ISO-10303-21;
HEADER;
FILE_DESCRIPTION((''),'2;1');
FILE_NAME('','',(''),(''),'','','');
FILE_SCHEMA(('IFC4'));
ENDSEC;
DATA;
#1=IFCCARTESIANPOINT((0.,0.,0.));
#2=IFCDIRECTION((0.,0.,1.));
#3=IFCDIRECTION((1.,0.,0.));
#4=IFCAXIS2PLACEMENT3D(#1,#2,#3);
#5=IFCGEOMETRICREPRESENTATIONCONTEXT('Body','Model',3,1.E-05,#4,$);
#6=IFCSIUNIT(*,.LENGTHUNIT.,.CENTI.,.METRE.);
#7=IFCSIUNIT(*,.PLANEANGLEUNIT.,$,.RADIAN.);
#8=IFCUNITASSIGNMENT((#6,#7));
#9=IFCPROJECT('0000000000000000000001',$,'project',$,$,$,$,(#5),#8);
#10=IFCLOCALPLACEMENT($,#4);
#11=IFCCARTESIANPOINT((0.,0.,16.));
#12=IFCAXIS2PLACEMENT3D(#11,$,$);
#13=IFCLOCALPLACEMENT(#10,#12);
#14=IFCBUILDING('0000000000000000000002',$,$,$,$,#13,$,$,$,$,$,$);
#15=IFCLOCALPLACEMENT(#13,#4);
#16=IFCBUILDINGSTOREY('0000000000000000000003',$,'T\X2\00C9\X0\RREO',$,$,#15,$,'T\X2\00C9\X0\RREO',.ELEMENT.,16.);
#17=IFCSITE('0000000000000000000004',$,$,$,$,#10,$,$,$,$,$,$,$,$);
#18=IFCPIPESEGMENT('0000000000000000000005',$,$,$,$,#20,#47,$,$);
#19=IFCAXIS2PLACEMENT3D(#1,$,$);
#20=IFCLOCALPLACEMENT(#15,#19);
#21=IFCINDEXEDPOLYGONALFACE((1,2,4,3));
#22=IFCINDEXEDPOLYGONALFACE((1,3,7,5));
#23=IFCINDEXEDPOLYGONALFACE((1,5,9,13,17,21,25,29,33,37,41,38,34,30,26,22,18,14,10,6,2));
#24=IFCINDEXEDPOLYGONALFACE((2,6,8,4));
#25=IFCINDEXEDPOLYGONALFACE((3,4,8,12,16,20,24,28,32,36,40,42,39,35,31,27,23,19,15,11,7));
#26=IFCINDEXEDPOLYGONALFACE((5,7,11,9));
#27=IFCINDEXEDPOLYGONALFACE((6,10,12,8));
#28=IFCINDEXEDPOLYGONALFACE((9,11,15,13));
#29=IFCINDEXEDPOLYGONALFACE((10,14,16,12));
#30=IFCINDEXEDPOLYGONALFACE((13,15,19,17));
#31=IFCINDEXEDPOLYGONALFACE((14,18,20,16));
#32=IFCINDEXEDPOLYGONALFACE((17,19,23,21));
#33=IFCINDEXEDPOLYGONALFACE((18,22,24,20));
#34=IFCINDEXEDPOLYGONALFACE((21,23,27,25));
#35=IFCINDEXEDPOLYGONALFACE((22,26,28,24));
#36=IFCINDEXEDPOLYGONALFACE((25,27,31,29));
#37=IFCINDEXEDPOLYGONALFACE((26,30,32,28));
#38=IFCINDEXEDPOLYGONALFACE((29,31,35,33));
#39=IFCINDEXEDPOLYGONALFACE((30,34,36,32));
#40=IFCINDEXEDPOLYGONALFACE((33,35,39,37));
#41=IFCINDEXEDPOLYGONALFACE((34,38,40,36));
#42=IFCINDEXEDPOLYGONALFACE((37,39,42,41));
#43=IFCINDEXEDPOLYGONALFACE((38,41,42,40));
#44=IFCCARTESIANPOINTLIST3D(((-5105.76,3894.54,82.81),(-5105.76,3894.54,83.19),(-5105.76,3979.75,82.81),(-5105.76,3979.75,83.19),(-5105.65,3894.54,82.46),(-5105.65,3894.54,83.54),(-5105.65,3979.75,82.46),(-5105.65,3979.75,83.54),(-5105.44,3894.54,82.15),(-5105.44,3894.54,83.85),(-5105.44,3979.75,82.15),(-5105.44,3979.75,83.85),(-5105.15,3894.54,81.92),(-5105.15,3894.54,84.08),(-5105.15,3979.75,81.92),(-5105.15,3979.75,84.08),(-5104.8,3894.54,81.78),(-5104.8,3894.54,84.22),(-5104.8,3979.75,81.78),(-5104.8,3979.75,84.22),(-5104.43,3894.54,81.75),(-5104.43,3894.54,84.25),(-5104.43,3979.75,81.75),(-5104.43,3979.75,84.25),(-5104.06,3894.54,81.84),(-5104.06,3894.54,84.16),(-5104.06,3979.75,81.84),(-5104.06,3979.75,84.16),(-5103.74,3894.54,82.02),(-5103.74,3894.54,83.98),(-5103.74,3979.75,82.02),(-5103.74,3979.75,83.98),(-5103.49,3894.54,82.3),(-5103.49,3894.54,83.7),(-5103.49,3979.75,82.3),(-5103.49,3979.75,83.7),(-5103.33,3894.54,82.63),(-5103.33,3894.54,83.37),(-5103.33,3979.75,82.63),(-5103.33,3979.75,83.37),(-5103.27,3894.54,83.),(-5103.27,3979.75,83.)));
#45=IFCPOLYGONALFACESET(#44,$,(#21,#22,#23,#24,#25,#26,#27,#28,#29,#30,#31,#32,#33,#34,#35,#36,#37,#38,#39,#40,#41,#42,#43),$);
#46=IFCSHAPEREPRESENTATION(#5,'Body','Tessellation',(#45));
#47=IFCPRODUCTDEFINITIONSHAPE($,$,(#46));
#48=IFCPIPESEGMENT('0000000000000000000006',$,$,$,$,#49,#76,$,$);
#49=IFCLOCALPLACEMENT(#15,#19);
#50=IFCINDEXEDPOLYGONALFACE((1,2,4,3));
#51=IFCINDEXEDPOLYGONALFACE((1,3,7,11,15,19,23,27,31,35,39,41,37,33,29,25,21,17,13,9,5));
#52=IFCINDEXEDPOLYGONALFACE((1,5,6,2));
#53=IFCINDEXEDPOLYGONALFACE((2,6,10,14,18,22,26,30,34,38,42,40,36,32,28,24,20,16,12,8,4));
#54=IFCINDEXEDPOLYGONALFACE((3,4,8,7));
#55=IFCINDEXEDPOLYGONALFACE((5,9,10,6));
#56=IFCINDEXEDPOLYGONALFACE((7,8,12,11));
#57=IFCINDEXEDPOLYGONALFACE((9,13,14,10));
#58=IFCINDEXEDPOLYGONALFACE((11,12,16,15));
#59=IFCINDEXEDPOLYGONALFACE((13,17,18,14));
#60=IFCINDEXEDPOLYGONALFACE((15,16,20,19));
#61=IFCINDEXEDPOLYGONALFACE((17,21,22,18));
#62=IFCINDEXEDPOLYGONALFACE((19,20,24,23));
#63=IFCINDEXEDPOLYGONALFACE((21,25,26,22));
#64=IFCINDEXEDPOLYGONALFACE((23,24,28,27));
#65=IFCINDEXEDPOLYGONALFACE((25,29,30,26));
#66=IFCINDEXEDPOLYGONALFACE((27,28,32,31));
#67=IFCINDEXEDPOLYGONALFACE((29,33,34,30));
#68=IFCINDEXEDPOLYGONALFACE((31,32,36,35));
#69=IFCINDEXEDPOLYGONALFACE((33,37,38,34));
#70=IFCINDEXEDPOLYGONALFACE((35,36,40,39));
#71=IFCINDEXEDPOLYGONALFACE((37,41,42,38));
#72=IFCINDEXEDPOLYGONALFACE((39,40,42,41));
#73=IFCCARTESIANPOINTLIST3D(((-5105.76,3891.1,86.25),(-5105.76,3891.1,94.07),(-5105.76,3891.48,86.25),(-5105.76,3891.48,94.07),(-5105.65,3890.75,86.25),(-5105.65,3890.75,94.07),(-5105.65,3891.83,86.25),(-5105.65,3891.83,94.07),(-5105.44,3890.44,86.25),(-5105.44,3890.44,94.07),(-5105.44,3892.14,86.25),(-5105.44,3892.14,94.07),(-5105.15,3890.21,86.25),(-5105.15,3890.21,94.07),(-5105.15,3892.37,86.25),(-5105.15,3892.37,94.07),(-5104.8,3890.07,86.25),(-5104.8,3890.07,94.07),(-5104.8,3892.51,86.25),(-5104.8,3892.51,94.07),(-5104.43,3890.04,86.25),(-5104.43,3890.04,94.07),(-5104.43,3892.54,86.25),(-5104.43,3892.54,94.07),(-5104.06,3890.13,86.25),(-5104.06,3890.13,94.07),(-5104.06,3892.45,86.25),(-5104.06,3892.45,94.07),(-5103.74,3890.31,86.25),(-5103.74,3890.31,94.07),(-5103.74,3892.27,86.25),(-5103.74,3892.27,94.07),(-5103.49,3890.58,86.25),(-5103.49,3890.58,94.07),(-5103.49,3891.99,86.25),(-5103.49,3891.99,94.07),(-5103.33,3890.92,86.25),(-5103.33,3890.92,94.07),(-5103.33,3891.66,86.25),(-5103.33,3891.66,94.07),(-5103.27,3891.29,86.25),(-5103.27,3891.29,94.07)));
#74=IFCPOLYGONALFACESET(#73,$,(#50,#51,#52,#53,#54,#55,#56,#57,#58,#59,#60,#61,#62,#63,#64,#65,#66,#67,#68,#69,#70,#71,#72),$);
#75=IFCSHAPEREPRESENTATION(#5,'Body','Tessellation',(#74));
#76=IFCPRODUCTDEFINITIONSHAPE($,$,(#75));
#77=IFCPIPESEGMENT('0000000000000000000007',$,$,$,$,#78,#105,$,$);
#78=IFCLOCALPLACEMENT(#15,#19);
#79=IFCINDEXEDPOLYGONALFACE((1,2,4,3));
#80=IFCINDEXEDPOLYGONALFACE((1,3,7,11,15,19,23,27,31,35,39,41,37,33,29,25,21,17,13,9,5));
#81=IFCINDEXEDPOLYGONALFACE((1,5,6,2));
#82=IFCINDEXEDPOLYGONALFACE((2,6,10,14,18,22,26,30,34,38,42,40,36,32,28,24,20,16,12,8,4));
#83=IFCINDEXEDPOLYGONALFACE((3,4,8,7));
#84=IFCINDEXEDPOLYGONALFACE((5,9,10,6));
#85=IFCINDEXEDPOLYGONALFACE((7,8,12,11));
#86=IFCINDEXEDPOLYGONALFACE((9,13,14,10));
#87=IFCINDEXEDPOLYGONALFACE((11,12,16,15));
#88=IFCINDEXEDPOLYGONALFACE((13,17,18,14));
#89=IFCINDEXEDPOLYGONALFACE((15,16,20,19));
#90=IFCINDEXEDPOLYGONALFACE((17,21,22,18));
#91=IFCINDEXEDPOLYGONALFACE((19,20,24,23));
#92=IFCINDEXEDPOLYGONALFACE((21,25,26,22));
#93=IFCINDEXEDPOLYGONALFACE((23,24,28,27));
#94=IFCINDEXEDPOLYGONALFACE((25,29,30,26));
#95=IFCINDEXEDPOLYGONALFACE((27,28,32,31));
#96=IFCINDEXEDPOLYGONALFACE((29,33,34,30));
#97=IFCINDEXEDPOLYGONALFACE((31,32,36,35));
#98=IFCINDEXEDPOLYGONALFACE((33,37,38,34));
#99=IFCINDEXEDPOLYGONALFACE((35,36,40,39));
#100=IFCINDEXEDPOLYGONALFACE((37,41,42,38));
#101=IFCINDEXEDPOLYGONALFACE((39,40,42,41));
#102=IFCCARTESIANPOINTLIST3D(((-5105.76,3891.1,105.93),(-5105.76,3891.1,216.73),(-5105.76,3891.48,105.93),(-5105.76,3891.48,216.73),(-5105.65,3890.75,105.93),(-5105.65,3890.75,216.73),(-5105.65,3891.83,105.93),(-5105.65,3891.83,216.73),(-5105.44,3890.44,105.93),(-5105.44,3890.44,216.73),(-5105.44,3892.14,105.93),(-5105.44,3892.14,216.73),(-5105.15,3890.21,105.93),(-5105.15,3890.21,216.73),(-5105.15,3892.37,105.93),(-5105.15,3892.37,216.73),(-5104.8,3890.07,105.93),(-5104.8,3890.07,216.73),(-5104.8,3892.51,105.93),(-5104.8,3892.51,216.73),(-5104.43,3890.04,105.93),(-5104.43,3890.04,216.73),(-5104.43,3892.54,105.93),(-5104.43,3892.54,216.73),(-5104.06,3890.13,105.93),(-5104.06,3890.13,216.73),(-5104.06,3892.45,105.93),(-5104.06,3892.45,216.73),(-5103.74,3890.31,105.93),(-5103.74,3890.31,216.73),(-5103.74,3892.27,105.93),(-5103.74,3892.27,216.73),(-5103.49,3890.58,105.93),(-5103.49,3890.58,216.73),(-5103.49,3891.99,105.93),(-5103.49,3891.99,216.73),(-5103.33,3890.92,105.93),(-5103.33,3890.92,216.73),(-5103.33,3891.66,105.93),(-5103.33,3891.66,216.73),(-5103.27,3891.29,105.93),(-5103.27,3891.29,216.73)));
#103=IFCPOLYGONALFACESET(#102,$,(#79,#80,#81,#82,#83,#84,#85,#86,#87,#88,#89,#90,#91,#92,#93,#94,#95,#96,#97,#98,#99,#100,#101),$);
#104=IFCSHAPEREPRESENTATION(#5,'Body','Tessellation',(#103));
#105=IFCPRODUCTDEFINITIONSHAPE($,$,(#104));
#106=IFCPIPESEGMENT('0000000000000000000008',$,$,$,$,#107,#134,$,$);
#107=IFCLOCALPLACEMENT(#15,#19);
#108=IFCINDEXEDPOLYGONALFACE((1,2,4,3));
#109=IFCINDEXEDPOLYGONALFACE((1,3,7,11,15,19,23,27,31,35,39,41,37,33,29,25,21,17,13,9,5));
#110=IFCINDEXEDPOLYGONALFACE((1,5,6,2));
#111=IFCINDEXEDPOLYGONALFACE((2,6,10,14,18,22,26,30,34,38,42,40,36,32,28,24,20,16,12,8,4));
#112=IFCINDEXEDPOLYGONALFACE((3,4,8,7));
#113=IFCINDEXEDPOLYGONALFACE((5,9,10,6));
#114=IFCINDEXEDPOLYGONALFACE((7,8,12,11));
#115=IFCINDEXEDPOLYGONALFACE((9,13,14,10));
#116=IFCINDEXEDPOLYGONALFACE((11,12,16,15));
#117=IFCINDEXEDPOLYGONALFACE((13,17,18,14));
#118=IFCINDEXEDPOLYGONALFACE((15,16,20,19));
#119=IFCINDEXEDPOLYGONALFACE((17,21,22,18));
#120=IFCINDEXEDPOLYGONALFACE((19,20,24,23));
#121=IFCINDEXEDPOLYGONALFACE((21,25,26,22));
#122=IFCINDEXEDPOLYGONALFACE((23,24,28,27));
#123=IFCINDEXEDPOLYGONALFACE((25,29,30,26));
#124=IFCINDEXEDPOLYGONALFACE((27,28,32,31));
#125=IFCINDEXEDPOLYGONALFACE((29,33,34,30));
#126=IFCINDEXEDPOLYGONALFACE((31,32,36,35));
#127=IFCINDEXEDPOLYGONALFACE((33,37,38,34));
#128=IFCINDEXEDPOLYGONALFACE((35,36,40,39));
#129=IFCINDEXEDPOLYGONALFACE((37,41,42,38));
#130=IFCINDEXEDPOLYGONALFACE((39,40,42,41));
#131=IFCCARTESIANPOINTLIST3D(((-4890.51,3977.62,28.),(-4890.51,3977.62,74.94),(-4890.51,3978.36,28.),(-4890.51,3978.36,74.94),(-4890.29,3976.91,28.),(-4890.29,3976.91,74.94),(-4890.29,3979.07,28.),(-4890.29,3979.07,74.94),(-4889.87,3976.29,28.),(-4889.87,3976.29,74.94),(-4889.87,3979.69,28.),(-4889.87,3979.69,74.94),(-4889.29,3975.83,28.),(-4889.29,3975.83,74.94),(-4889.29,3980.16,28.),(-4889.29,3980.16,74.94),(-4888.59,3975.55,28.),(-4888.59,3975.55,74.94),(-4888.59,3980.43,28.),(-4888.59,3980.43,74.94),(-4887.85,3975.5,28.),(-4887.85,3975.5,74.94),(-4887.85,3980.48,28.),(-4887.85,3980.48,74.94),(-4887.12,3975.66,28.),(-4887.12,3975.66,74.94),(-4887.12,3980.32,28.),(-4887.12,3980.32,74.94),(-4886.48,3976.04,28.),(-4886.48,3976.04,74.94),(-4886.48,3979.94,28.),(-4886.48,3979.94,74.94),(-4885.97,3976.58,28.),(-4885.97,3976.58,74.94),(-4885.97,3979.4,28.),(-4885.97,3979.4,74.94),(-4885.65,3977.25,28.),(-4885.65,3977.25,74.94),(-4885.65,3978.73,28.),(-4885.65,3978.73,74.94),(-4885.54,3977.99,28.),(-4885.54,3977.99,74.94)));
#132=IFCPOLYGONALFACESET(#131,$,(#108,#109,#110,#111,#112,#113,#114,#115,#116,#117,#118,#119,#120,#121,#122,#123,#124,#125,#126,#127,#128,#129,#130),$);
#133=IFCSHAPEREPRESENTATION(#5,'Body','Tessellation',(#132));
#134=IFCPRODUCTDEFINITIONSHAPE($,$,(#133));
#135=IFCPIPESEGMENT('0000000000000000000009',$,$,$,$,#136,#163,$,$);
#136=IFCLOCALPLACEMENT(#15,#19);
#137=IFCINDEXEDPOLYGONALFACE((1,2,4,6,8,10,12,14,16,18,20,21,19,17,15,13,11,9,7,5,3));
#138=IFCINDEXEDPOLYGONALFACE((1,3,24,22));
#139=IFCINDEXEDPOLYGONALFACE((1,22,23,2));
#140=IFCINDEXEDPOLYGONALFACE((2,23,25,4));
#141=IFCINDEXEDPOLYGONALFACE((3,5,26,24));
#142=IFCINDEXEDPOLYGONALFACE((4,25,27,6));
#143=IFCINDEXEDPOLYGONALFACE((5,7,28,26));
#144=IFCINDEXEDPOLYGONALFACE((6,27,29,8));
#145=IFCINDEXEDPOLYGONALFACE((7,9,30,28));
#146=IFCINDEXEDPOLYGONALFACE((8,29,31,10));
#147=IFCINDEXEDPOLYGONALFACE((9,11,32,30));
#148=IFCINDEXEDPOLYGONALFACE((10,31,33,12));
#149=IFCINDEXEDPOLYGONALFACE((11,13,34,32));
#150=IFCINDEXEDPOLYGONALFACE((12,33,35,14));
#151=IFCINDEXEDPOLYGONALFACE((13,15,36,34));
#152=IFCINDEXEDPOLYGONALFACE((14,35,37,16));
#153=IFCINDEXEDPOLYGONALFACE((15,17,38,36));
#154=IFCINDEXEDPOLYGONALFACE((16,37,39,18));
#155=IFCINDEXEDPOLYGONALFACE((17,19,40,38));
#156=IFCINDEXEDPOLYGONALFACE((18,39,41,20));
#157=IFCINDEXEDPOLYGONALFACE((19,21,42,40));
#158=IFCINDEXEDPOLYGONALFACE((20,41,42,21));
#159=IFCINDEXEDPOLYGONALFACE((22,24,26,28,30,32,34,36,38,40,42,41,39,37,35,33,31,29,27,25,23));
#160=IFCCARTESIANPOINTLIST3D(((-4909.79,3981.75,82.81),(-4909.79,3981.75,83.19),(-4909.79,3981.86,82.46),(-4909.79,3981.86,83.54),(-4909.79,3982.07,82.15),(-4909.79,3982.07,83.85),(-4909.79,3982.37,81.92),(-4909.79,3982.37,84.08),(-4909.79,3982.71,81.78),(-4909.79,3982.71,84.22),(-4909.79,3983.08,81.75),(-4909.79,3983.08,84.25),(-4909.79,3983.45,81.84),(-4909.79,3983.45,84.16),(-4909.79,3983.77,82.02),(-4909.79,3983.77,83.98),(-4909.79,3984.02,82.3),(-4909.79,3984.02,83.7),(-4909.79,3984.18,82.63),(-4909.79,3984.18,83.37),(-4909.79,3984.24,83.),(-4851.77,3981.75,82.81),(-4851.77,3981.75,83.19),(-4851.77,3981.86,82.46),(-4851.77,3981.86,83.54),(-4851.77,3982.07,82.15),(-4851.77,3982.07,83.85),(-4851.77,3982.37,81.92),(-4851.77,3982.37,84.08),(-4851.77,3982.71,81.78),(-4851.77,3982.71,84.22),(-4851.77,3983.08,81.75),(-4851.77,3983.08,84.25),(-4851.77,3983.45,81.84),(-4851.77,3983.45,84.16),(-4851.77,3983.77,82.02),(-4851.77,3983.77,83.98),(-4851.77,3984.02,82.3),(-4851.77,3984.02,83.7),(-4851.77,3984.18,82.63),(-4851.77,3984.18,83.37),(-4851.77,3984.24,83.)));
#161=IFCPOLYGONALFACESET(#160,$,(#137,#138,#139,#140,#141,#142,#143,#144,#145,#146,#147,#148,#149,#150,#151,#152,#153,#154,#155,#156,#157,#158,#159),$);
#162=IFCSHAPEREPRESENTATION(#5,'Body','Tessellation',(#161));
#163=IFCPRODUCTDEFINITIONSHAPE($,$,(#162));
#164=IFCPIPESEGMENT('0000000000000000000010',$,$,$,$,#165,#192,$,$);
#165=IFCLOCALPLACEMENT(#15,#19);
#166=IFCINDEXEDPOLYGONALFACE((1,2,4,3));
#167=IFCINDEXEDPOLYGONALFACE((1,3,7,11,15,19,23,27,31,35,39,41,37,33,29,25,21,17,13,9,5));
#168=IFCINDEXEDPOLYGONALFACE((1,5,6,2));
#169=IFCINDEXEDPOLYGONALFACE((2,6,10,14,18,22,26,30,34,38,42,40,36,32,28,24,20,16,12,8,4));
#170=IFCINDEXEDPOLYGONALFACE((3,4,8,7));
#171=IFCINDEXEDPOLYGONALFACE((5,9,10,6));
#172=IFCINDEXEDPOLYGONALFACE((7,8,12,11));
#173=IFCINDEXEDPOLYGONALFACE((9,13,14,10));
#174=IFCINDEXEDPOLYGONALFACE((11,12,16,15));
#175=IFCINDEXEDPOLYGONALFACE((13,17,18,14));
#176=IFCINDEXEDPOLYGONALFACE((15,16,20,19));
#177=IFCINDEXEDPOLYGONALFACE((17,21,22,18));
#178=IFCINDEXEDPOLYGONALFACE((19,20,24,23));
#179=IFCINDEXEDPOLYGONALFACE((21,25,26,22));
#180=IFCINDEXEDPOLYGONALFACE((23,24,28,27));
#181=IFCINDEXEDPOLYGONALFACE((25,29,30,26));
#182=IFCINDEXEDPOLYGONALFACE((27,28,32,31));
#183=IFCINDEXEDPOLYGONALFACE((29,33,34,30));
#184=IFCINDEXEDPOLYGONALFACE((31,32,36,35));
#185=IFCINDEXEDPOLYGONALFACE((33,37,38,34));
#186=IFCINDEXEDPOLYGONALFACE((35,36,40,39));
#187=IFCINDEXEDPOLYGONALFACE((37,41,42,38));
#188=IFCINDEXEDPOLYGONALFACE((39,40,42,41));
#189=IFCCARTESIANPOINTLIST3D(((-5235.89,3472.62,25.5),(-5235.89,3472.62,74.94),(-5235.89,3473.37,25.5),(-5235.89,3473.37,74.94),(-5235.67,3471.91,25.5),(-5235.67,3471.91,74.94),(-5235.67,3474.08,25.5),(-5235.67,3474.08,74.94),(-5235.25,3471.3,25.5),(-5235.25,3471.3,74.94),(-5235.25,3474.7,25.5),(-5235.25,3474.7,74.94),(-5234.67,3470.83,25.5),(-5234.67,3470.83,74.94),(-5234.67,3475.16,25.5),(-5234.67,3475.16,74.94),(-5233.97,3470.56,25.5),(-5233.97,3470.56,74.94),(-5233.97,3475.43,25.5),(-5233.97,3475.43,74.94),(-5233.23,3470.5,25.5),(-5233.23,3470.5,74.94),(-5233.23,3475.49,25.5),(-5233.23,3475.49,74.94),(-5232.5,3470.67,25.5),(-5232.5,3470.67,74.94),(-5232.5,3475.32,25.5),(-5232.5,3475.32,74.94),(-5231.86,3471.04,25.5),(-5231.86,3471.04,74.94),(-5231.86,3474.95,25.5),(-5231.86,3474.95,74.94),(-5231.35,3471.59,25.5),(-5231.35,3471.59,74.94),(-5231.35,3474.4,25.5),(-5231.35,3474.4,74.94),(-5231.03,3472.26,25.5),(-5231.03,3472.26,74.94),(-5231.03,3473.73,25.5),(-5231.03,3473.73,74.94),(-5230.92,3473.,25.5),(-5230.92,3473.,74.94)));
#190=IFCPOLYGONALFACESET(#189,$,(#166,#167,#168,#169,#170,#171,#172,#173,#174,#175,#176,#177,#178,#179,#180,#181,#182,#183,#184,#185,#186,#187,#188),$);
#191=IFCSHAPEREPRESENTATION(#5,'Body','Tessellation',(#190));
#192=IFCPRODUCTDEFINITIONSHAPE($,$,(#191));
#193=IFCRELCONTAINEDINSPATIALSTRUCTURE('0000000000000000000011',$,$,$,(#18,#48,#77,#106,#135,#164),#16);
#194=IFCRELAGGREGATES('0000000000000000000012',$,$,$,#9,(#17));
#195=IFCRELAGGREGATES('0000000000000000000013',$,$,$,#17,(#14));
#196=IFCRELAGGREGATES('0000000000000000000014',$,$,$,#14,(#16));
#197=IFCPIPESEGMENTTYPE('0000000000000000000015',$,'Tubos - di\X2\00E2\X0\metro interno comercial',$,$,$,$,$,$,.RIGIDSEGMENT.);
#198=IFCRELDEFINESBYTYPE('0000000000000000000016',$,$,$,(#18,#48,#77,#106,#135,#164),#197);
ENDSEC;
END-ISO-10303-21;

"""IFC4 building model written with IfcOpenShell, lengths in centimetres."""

from ifc_helpers import new_model, si_unit, frame, origin_with_axes, origin_2d_with_axis, place, context, project, spatial, circle, extrude, type_object, element, save


model = new_model("IFC4")

# Units and contexts
model_context = context("Model", 3, precision=1e-05, world=origin_with_axes(), identifier="Body")
ifc_project = project(units=[si_unit("LENGTHUNIT", "METRE", prefix="CENTI"), si_unit("PLANEANGLEUNIT", "RADIAN")], contexts=[model_context])

# Site, building, storey
site_placement = place(None, origin_with_axes())
site = spatial("IfcSite", under=ifc_project, at=site_placement)
building_placement = place(site_placement, frame((0.0, 0.0, 16.0)))
building = spatial("IfcBuilding", under=site, at=building_placement)
storey_placement = place(building_placement, origin_with_axes())
storey = spatial("IfcBuildingStorey", under=building, at=storey_placement, Name="TÉRREO", LongName="TÉRREO", CompositionType="ELEMENT", Elevation=16.0)

# Pipe segments
pipe_segment_type = type_object("IfcPipeSegmentType", Name="Tubos - diâmetro interno comercial", PredefinedType="RIGIDSEGMENT")
pipe_segment_1_placement = place(storey_placement, frame((-5104.52, 3937.14, 84.25), z_axis=(0.0, 0.0, 1.0), x_axis=(1.0, 0.0, 0.0)))
element("IfcPipeSegment", 1, at=pipe_segment_1_placement, inside=storey, type_object=pipe_segment_type, context=model_context, shape_type="SolidModel", body=[
    extrude(circle(Radius=1.25, at=origin_2d_with_axis()), frame((0.0, 42.6, -1.25), z_axis=(0.0, -1.0, 0.0), x_axis=(1.0, 0.0, 0.0)), (0.0, 0.0, 1.0), 85.21),
])
pipe_segment_2_placement = place(storey_placement, frame((-5104.52, 3891.29, 94.07), z_axis=(0.0, 0.0, 1.0), x_axis=(1.0, 0.0, 0.0)))
element("IfcPipeSegment", 2, at=pipe_segment_2_placement, inside=storey, type_object=pipe_segment_type, context=model_context, shape_type="SolidModel", body=[
    extrude(circle(Radius=1.25, at=origin_2d_with_axis()), frame((0.0, 0.0, -7.82), z_axis=(0.0, 0.0, 1.0), x_axis=(1.0, 0.0, 0.0)), (0.0, 0.0, 1.0), 7.82),
])
pipe_segment_3_placement = place(storey_placement, frame((-5104.52, 3891.29, 216.73), z_axis=(0.0, 0.0, 1.0), x_axis=(1.0, 0.0, 0.0)))
element("IfcPipeSegment", 3, at=pipe_segment_3_placement, inside=storey, type_object=pipe_segment_type, context=model_context, shape_type="SolidModel", body=[
    extrude(circle(Radius=1.25, at=origin_2d_with_axis()), frame((0.0, 0.0, -110.8), z_axis=(0.0, 0.0, 1.0), x_axis=(1.0, 0.0, 0.0)), (0.0, 0.0, 1.0), 110.8),
])
pipe_segment_4_placement = place(storey_placement, frame((-4888.04, 3977.99, 74.94), z_axis=(0.0, 0.0, 1.0), x_axis=(1.0, 0.0, 0.0)))
element("IfcPipeSegment", 4, at=pipe_segment_4_placement, inside=storey, type_object=pipe_segment_type, context=model_context, shape_type="SolidModel", body=[
    extrude(circle(Radius=2.5, at=origin_2d_with_axis()), frame((0.0, 0.0, 0.0), z_axis=(0.0, 0.0, -1.0), x_axis=(1.0, 0.0, 0.0)), (0.0, 0.0, 1.0), 46.94),
])
pipe_segment_5_placement = place(storey_placement, frame((-4880.78, 3982.99, 84.25), z_axis=(0.0, 0.0, 1.0), x_axis=(1.0, 0.0, 0.0)))
element("IfcPipeSegment", 5, at=pipe_segment_5_placement, inside=storey, type_object=pipe_segment_type, context=model_context, shape_type="SolidModel", body=[
    extrude(circle(Radius=1.25, at=origin_2d_with_axis()), frame((29.01, 0.0, -1.25), z_axis=(-1.0, 0.0, 0.0), x_axis=(0.0, 1.0, 0.0)), (0.0, 0.0, 1.0), 58.02),
])
for number, where, z_axis, x_axis in (
    (6, (-5233.42, 3473.0, 74.94), (0.0, 0.0, 1.0), (1.0, 0.0, 0.0)),
):
    element("IfcPipeSegment", number, at=place(storey_placement, frame(where, z_axis=z_axis, x_axis=x_axis)), inside=storey, type_object=pipe_segment_type, context=model_context, shape_type="SolidModel", body=[
        extrude(circle(Radius=2.5, at=origin_2d_with_axis()), frame((0.0, 0.0, 0.0), z_axis=(0.0, 0.0, -1.0), x_axis=(1.0, 0.0, 0.0)), (0.0, 0.0, 1.0), 49.44),
    ])

save(model, "model.ifc")
